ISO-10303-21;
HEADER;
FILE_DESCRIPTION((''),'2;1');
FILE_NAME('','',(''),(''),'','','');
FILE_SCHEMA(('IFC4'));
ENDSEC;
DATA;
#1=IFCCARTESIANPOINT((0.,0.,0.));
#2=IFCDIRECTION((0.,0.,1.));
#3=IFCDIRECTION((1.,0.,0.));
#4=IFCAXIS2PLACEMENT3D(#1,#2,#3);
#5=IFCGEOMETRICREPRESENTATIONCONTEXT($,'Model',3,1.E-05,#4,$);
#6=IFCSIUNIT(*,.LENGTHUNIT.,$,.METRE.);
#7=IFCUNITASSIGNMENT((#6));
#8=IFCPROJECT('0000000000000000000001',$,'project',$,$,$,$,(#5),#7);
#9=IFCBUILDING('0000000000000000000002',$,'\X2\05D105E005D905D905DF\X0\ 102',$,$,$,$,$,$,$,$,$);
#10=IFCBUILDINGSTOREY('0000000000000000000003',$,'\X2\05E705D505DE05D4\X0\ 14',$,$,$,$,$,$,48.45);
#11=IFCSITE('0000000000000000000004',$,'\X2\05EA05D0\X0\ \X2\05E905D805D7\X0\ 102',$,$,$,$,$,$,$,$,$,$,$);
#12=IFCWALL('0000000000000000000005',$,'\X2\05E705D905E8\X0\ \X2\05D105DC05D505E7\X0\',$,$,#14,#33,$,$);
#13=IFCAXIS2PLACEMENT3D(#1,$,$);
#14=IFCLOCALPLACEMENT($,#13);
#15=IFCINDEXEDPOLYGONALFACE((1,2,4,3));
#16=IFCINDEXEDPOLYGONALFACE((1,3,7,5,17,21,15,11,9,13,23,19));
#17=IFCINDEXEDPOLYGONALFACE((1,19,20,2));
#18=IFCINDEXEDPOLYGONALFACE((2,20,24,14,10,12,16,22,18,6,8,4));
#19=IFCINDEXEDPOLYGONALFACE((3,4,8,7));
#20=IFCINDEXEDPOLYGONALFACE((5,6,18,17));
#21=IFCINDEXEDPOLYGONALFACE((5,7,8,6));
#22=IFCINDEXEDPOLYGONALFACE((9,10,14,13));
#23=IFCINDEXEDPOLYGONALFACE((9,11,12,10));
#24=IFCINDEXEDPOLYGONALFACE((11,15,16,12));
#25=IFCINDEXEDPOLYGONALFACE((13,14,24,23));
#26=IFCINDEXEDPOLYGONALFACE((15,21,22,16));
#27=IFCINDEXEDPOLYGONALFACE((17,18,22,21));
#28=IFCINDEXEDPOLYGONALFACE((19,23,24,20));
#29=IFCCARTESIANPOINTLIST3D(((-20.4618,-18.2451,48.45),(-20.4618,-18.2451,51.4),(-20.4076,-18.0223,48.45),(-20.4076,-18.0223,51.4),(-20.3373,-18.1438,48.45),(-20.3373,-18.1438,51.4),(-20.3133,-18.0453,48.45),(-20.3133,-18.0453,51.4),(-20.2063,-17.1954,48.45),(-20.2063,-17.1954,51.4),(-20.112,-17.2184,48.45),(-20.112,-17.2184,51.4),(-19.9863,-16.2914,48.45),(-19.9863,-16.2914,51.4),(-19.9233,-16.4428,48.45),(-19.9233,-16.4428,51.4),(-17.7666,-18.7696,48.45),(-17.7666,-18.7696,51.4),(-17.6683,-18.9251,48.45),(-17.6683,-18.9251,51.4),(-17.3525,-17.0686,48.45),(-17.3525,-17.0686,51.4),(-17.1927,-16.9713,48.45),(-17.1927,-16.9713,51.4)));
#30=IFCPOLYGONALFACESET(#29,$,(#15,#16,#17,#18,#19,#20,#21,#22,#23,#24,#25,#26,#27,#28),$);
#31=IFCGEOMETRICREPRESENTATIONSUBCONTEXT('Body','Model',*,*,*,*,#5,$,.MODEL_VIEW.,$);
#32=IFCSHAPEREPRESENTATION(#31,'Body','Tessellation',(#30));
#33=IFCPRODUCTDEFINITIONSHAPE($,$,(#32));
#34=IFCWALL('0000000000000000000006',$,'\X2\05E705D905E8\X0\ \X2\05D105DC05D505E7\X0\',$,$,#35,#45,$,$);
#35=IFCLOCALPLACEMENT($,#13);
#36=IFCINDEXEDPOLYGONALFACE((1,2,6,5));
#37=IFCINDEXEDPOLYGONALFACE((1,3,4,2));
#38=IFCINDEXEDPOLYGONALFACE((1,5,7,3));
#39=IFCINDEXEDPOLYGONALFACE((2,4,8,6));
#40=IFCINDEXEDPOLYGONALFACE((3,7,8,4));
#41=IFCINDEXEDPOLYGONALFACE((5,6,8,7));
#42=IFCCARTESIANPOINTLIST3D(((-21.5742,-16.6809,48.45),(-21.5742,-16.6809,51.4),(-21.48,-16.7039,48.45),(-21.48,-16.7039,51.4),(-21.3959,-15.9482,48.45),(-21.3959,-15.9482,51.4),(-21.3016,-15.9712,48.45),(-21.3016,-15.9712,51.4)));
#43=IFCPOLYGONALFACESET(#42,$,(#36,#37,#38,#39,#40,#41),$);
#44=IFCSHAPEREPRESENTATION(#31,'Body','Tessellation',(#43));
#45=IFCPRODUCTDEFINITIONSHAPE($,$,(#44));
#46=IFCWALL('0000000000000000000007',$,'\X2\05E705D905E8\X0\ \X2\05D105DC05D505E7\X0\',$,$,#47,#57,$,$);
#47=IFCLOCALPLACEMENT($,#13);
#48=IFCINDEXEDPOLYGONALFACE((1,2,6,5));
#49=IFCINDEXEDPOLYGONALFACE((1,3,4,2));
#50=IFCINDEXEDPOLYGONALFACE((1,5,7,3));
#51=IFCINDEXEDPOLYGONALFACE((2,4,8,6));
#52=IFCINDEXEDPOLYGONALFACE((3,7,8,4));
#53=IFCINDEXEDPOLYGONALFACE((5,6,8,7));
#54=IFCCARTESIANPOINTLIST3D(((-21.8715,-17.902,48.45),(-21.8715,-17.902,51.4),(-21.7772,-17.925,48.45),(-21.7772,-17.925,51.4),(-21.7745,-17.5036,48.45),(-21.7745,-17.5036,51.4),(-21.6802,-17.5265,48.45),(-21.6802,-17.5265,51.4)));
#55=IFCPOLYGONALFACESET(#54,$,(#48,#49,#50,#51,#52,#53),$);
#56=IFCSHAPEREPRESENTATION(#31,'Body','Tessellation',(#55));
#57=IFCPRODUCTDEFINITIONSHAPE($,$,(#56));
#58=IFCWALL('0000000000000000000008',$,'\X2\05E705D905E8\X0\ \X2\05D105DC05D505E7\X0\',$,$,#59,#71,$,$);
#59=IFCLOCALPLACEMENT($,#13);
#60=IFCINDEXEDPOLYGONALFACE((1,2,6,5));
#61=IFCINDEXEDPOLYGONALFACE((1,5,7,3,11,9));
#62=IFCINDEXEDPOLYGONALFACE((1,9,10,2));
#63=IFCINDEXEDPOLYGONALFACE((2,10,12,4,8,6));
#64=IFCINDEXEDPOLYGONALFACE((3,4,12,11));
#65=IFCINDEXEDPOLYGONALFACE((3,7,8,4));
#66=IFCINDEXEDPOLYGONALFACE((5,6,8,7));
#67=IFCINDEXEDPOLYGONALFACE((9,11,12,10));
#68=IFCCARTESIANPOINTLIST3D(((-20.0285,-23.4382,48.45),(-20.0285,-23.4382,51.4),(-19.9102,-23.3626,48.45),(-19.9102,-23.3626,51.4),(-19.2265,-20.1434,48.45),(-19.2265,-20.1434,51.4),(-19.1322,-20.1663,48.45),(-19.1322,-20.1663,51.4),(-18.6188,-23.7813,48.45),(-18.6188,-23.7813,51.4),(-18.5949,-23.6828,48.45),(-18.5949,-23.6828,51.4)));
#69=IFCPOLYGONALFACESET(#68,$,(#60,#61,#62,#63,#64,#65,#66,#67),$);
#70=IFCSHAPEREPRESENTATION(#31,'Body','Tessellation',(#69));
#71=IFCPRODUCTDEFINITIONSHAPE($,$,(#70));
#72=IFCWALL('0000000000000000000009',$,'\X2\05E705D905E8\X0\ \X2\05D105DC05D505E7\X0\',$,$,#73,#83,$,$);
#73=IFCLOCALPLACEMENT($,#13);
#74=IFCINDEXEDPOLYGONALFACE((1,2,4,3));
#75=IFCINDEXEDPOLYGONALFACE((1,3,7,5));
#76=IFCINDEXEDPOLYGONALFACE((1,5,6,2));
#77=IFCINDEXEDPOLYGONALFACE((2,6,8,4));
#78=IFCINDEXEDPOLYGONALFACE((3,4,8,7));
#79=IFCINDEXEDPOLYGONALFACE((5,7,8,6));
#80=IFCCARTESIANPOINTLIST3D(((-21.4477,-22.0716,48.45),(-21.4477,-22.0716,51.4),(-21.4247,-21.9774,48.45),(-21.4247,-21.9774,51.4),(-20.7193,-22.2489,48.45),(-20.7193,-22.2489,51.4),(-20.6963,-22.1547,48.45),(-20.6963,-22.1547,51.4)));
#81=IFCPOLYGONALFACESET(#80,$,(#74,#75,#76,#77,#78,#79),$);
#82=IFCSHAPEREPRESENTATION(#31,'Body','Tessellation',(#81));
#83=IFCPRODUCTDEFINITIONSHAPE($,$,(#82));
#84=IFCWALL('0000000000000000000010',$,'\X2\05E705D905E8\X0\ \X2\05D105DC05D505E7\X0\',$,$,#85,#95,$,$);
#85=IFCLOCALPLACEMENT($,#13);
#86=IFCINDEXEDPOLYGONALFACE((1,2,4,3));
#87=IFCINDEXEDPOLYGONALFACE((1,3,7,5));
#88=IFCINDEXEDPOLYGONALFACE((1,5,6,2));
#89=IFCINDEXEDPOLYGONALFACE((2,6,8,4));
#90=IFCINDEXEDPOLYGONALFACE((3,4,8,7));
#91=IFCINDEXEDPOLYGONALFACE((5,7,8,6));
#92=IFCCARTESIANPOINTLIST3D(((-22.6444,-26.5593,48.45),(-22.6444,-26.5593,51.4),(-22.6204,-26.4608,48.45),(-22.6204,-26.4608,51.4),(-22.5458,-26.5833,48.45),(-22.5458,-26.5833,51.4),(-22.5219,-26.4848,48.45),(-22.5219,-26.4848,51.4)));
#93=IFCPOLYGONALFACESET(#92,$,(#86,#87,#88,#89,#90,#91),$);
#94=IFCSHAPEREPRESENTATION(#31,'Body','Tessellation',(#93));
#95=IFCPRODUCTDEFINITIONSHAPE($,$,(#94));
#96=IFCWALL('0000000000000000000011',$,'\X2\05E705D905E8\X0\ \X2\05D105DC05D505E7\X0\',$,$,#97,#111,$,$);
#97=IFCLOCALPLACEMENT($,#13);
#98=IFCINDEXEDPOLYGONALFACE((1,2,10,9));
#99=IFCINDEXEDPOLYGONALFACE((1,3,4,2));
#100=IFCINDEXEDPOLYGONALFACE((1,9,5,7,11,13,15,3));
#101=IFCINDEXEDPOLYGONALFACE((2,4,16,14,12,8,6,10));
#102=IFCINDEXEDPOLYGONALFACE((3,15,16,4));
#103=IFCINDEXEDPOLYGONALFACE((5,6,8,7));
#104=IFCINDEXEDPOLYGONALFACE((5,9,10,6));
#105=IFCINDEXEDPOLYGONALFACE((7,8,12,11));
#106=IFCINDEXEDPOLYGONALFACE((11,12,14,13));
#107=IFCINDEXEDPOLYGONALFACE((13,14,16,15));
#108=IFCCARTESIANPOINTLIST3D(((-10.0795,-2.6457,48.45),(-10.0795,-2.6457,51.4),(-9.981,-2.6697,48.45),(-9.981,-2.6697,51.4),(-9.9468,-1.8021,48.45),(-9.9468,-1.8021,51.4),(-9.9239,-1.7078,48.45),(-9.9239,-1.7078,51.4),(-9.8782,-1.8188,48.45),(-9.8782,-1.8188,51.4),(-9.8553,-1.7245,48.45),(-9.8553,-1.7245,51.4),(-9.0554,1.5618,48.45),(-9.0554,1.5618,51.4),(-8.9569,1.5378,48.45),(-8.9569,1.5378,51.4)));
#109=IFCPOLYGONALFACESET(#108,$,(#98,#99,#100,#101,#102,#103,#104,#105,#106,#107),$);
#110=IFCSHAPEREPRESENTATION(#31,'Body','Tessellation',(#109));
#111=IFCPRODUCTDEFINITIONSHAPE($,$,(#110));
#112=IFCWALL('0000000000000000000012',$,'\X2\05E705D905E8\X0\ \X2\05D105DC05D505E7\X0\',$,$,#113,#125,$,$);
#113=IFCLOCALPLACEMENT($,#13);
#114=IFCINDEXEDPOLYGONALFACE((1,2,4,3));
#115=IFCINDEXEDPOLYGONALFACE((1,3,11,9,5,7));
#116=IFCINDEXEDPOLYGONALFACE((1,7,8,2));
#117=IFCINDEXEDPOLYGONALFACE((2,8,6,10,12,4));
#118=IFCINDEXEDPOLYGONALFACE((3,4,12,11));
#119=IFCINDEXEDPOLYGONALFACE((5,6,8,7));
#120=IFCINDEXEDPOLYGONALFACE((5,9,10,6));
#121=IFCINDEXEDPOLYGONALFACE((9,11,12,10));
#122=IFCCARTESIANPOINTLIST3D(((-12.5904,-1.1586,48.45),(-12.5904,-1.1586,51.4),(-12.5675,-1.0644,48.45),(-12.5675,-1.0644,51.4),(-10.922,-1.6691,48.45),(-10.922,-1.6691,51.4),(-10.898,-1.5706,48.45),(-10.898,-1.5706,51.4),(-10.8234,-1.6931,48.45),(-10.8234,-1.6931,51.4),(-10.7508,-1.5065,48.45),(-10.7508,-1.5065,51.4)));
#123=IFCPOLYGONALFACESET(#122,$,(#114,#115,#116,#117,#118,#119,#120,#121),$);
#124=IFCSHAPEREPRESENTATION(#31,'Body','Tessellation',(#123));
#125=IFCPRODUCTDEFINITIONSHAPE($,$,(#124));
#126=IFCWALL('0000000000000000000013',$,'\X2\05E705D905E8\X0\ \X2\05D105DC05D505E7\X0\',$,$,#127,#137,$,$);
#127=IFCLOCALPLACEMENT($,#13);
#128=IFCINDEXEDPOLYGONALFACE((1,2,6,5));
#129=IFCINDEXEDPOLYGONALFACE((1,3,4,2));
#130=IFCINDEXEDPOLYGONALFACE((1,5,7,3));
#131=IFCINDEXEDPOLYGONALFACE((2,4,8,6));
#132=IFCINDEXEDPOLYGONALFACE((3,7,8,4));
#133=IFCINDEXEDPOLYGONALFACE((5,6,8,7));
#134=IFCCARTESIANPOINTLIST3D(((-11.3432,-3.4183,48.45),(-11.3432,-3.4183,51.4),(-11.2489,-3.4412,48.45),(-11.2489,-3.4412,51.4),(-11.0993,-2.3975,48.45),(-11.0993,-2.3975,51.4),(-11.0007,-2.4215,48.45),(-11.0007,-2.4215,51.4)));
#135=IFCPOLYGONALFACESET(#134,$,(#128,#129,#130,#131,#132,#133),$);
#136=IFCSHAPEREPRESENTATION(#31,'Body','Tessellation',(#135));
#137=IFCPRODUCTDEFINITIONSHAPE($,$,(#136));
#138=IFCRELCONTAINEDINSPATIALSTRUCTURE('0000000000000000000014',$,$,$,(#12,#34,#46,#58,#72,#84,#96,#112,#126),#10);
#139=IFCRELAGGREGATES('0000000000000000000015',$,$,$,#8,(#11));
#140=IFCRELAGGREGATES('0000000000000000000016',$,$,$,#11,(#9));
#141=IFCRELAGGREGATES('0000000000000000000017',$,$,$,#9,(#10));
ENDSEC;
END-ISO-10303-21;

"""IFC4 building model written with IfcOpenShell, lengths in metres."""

from ifc_helpers import new_model, si_unit, frame, origin_with_axes, context, subcontext, project, spatial, polyline, outline, extrude, element, save


model = new_model("IFC4")

# Units and contexts
model_context = context("Model", 3, precision=1e-05, world=origin_with_axes())
body_context = subcontext(model_context, "Body", "Model", "MODEL_VIEW")
ifc_project = project(units=[si_unit("LENGTHUNIT", "METRE")], contexts=[model_context])

# Site, building, storey
site = spatial("IfcSite", under=ifc_project, Name="תא שטח 102")
building = spatial("IfcBuilding", under=site, Name="בניין 102")
storey = spatial("IfcBuildingStorey", under=building, Name="קומה 14", Elevation=48.45)

# Walls
element("IfcWall", 1, inside=storey, Name="קיר בלוק", context=body_context, shape_type="SweptSolid", body=[
    extrude(outline(polyline([(-19.9233, -16.4428), (-17.3525, -17.0686), (-17.7666, -18.7696), (-20.3373, -18.1438), (-20.3133, -18.0453), (-20.4076, -18.0223), (-20.4618, -18.2451), (-17.6683, -18.9251), (-17.1927, -16.9713), (-19.9863, -16.2914), (-20.2063, -17.1954), (-20.112, -17.2184), (-19.9233, -16.4428)])), frame((0.0, 0.0, 48.45)), (0.0, 0.0, 1.0), 2.95),
])
element("IfcWall", 2, inside=storey, Name="קיר בלוק", context=body_context, shape_type="SweptSolid", body=[
    extrude(outline(polyline([(-21.3959, -15.9482), (-21.5742, -16.6809), (-21.48, -16.7039), (-21.3016, -15.9712), (-21.3959, -15.9482)])), frame((0.0, 0.0, 48.45)), (0.0, 0.0, 1.0), 2.95),
])
element("IfcWall", 3, inside=storey, Name="קיר בלוק", context=body_context, shape_type="SweptSolid", body=[
    extrude(outline(polyline([(-21.8715, -17.902), (-21.7772, -17.925), (-21.6802, -17.5265), (-21.7745, -17.5036), (-21.8715, -17.902)])), frame((0.0, 0.0, 48.45)), (0.0, 0.0, 1.0), 2.95),
])
element("IfcWall", 4, inside=storey, Name="קיר בלוק", context=body_context, shape_type="SweptSolid", body=[
    extrude(outline(polyline([(-18.5949, -23.6828), (-19.9102, -23.3626), (-19.1322, -20.1663), (-19.2265, -20.1434), (-20.0285, -23.4382), (-18.6188, -23.7813), (-18.5949, -23.6828)])), frame((0.0, 0.0, 48.45)), (0.0, 0.0, 1.0), 2.95),
])
element("IfcWall", 5, inside=storey, Name="קיר בלוק", context=body_context, shape_type="SweptSolid", body=[
    extrude(outline(polyline([(-21.4477, -22.0716), (-20.7193, -22.2489), (-20.6963, -22.1547), (-21.4247, -21.9774), (-21.4477, -22.0716)])), frame((0.0, 0.0, 48.45)), (0.0, 0.0, 1.0), 2.95),
])
element("IfcWall", 6, inside=storey, Name="קיר בלוק", context=body_context, shape_type="SweptSolid", body=[
    extrude(outline(polyline([(-22.6444, -26.5593), (-22.5458, -26.5833), (-22.5219, -26.4848), (-22.6204, -26.4608), (-22.6444, -26.5593)])), frame((0.0, 0.0, 48.45)), (0.0, 0.0, 1.0), 2.95),
])
element("IfcWall", 7, inside=storey, Name="קיר בלוק", context=body_context, shape_type="SweptSolid", body=[
    extrude(outline(polyline([(-10.0795, -2.6457), (-9.981, -2.6697), (-8.9569, 1.5378), (-9.0554, 1.5618), (-9.8553, -1.7245), (-9.9239, -1.7078), (-9.9468, -1.8021), (-9.8782, -1.8188), (-10.0795, -2.6457)])), frame((0.0, 0.0, 48.45)), (0.0, 0.0, 1.0), 2.95),
])
element("IfcWall", 8, inside=storey, Name="קיר בלוק", context=body_context, shape_type="SweptSolid", body=[
    extrude(outline(polyline([(-10.922, -1.6691), (-10.8234, -1.6931), (-10.7508, -1.5065), (-12.5675, -1.0644), (-12.5904, -1.1586), (-10.898, -1.5706), (-10.922, -1.6691)])), frame((0.0, 0.0, 48.45)), (0.0, 0.0, 1.0), 2.95),
])
element("IfcWall", 9, inside=storey, Name="קיר בלוק", context=body_context, shape_type="SweptSolid", body=[
    extrude(outline(polyline([(-11.2489, -3.4412), (-11.0007, -2.4215), (-11.0993, -2.3975), (-11.3432, -3.4183), (-11.2489, -3.4412)])), frame((0.0, 0.0, 48.45)), (0.0, 0.0, 1.0), 2.95),
])

save(model, "model.ifc")
